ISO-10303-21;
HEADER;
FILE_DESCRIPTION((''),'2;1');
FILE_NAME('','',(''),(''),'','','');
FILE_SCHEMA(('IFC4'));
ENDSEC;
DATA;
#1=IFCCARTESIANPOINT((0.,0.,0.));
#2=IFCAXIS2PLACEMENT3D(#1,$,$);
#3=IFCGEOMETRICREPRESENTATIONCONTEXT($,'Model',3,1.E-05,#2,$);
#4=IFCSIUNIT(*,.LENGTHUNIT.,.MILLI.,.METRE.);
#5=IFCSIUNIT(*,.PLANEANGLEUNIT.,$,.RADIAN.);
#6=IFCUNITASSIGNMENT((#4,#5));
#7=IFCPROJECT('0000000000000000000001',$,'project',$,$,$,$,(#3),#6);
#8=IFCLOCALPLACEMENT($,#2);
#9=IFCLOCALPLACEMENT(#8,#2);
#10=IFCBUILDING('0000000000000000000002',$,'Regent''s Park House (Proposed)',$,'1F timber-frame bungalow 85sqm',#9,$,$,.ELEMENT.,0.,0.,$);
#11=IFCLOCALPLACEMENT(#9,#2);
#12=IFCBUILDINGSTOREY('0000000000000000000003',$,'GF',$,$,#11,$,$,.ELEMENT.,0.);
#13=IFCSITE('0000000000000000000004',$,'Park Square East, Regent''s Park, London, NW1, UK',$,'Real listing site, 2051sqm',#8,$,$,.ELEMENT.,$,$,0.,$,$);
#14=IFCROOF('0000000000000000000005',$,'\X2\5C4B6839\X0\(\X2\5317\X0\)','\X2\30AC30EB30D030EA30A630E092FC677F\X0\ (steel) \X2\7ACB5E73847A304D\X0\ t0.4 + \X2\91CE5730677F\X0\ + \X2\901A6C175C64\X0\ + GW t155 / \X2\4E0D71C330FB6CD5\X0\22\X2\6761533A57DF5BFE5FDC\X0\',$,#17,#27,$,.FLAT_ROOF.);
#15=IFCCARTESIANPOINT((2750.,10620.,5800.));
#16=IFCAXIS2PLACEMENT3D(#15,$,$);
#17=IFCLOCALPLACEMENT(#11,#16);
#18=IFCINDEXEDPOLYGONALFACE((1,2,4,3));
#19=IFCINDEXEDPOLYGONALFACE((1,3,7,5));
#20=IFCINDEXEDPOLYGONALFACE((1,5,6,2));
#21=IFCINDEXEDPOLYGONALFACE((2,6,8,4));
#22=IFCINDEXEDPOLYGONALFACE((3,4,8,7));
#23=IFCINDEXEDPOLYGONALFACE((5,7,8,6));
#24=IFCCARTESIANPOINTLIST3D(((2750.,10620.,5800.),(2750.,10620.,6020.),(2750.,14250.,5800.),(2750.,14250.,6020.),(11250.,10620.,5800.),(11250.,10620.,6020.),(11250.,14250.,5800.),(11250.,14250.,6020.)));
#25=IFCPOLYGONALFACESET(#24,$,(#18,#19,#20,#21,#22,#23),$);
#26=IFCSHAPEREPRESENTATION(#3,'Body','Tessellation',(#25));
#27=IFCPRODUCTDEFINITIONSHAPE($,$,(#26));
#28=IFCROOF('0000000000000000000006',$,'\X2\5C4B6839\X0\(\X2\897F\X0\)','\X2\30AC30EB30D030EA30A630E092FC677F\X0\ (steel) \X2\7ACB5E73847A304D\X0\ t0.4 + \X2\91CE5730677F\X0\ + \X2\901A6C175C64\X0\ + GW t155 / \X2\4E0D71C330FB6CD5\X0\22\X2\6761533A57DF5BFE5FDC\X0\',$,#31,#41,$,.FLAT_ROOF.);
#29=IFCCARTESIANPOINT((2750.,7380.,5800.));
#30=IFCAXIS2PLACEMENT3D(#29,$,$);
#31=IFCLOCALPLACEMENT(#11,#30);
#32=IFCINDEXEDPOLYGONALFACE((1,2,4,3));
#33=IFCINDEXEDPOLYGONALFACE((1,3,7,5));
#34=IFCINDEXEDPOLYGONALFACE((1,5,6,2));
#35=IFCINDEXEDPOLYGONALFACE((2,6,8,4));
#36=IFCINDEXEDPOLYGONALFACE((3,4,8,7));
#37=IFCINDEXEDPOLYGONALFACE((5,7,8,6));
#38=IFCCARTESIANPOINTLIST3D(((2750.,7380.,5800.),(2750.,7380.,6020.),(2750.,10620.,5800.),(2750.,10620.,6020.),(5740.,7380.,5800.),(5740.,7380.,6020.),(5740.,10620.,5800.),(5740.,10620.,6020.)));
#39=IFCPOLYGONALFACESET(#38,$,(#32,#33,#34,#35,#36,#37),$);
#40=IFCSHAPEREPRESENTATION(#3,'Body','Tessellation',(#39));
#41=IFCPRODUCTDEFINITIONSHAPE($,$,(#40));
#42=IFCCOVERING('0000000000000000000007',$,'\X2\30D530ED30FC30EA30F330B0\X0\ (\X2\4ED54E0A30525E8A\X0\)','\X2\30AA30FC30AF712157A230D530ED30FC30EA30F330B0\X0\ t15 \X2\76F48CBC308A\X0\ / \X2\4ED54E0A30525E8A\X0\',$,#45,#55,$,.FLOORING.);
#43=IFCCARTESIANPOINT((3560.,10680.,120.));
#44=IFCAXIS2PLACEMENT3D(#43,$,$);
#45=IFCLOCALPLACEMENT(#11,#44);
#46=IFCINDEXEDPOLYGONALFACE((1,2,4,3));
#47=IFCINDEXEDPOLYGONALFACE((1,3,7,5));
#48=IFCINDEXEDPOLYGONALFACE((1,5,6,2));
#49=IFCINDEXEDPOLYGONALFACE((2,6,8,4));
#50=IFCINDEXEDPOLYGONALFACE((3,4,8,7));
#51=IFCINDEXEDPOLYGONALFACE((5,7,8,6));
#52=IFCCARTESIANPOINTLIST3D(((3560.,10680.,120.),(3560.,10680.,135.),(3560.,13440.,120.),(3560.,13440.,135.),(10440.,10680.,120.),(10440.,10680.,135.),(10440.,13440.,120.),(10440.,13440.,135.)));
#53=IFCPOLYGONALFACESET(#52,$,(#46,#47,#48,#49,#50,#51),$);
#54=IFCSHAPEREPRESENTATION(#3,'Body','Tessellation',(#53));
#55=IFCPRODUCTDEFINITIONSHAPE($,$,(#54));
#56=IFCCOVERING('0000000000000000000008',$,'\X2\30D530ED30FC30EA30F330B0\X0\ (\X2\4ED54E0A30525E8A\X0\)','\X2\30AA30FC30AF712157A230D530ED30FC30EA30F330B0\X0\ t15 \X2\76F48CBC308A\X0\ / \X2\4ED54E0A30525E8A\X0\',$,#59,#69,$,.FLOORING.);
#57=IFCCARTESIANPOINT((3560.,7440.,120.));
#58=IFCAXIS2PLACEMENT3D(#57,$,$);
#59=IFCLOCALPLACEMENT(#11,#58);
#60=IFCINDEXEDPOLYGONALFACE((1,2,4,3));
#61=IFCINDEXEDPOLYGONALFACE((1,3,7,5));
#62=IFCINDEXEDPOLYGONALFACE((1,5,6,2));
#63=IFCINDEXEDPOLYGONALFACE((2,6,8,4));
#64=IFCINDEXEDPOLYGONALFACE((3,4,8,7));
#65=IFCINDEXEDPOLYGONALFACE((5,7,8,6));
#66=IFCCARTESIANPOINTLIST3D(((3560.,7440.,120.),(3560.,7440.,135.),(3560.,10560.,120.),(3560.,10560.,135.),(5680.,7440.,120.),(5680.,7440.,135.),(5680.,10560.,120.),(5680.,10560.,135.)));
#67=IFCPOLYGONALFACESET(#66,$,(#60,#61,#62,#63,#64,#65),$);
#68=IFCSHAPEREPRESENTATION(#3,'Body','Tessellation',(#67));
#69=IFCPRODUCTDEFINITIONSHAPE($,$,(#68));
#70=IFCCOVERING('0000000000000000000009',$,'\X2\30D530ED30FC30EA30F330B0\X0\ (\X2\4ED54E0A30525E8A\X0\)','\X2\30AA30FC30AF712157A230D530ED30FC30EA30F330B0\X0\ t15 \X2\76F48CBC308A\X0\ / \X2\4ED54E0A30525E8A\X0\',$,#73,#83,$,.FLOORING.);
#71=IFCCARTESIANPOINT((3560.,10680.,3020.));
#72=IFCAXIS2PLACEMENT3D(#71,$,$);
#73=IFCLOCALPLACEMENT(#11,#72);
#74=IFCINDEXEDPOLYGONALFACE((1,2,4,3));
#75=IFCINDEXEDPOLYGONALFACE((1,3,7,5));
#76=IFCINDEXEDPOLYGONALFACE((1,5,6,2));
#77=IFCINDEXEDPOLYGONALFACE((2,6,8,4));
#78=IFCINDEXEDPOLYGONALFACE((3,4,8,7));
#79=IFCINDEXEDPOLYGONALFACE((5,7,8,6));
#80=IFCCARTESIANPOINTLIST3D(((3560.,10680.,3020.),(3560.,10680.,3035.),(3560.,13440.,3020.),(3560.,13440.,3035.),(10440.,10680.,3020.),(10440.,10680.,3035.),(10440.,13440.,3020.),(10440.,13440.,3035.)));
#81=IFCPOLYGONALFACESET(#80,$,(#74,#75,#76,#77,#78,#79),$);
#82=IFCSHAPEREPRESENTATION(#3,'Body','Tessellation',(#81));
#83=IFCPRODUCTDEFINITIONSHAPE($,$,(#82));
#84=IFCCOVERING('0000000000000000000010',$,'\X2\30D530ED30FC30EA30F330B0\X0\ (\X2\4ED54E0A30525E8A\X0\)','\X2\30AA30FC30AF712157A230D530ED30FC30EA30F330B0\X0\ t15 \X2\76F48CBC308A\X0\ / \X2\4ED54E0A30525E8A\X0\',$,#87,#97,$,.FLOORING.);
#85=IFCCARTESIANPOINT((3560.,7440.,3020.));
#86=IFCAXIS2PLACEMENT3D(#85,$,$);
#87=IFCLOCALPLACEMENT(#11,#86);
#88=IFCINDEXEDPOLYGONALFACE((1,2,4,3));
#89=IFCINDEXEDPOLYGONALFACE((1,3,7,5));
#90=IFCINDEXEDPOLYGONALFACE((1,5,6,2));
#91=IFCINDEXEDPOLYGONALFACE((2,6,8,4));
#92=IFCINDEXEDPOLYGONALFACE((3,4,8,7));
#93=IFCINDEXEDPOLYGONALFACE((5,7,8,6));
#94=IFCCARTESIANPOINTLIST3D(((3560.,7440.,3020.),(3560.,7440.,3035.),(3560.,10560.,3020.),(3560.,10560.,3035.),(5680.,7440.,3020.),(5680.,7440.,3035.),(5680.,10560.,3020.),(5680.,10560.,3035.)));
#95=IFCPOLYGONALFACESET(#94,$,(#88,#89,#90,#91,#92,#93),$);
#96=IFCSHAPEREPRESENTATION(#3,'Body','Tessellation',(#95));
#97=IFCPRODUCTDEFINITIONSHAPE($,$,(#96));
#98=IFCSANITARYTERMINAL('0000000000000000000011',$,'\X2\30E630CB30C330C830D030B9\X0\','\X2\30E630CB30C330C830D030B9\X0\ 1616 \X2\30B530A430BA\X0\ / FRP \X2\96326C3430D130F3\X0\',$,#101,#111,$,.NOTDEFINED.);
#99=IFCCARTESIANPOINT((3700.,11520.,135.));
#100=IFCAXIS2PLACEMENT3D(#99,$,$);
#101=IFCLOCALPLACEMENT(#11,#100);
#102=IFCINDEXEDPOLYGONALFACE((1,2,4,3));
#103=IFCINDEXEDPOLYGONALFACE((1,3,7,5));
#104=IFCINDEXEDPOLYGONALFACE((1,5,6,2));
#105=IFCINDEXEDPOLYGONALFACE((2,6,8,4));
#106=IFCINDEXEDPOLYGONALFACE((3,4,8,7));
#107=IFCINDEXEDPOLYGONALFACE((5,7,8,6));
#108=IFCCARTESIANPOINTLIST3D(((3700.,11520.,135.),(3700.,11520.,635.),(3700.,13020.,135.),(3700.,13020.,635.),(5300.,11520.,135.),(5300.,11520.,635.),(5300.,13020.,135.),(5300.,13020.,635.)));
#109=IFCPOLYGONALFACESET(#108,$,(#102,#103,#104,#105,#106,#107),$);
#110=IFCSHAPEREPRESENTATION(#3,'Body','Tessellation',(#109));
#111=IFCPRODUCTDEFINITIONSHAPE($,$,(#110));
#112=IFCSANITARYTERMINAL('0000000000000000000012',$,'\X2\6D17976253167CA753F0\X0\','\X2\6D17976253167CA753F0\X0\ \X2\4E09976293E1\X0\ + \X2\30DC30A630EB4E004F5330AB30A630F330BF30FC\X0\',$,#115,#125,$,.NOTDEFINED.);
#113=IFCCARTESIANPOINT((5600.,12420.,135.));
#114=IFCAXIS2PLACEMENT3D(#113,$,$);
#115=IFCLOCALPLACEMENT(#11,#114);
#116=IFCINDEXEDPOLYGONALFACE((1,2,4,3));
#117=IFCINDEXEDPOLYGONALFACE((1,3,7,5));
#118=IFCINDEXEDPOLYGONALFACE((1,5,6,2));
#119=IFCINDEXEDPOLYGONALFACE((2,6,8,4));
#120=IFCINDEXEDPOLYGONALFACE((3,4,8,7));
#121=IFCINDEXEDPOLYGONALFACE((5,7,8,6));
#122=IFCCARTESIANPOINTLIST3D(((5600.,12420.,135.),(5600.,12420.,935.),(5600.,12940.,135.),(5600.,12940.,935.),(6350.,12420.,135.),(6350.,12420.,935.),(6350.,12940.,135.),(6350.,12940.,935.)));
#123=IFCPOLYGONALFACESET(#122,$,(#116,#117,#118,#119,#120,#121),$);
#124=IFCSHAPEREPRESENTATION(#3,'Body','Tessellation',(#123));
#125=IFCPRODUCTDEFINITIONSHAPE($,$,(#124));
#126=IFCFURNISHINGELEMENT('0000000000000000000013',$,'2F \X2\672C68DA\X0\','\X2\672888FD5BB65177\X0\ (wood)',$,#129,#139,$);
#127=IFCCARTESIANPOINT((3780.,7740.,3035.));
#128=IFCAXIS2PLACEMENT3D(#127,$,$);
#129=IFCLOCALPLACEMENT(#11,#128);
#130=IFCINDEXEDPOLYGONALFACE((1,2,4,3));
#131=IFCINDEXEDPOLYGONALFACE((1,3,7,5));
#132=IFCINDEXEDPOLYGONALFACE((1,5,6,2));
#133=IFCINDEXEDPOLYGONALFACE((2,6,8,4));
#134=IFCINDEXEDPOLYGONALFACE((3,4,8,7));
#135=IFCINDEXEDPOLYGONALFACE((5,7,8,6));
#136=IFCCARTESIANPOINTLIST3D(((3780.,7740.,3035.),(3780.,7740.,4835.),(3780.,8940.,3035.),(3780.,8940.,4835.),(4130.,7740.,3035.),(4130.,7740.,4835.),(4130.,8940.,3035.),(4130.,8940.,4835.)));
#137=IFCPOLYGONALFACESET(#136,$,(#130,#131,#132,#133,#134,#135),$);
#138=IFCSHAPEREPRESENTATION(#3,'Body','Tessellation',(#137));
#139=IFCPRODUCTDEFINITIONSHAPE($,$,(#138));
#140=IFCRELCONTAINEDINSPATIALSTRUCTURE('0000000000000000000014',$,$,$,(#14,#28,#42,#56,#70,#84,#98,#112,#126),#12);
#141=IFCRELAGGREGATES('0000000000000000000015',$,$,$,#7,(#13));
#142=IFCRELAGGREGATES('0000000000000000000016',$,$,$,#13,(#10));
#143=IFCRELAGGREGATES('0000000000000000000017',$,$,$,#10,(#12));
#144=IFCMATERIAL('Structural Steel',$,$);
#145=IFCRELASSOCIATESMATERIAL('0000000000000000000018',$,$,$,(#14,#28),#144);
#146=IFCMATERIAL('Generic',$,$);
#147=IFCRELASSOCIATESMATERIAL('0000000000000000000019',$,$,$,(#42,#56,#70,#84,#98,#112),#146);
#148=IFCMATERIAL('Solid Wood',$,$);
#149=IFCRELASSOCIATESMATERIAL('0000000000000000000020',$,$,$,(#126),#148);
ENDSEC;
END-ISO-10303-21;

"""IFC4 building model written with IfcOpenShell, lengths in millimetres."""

from ifc_helpers import new_model, si_unit, frame, frame_2d, origin, place, context, project, spatial, rectangle, extrude, material, element, save


model = new_model("IFC4")

# Units and contexts
model_context = context("Model", 3, precision=1e-05, world=origin())
ifc_project = project(units=[si_unit("LENGTHUNIT", "METRE", prefix="MILLI"), si_unit("PLANEANGLEUNIT", "RADIAN")], contexts=[model_context])

# Site, building, storey
site_placement = place(None, origin())
site = spatial("IfcSite", under=ifc_project, at=site_placement, Name="Park Square East, Regent's Park, London, NW1, UK", ObjectType="Real listing site, 2051sqm", CompositionType="ELEMENT", RefElevation=0.0)
building_placement = place(site_placement, origin())
building = spatial("IfcBuilding", under=site, at=building_placement, Name="Regent's Park House (Proposed)", ObjectType="1F timber-frame bungalow 85sqm", CompositionType="ELEMENT", ElevationOfRefHeight=0.0, ElevationOfTerrain=0.0)
storey_placement = place(building_placement, origin())
storey = spatial("IfcBuildingStorey", under=building, at=storey_placement, Name="GF", CompositionType="ELEMENT", Elevation=0.0)

# Shared definitions
ifc_material_1 = material(Name="Solid Wood")

# Roofs
ifc_material_2 = material(Name="Structural Steel")
for number, where, name in (
    (1, (2750.0, 10620.0, 5800.0), "屋根(北)"),
):
    element("IfcRoof", number, at=place(storey_placement, frame(where)), inside=storey, material=ifc_material_2, Name=name, Description="ガルバリウム鋼板 (steel) 立平葺き t0.4 + 野地板 + 通気層 + GW t155 / 不燃・法22条区域対応", PredefinedType="FLAT_ROOF", context=model_context, shape_type="SweptSolid", body=[
        extrude(rectangle(XDim=8500.0, YDim=3630.0, at=frame_2d((4250.0, 1815.0))), frame((2750.0, 10620.0, 5800.0)), (0.0, 0.0, 1.0), 220.0),
    ])
roof_placement = place(storey_placement, frame((2750.0, 7380.0, 5800.0)))
element("IfcRoof", 2, at=roof_placement, inside=storey, material=ifc_material_2, Name="屋根(西)", Description="ガルバリウム鋼板 (steel) 立平葺き t0.4 + 野地板 + 通気層 + GW t155 / 不燃・法22条区域対応", PredefinedType="FLAT_ROOF", context=model_context, shape_type="SweptSolid", body=[
    extrude(rectangle(XDim=2990.0, YDim=3240.0, at=frame_2d((1495.0, 1620.0))), frame((2750.0, 7380.0, 5800.0)), (0.0, 0.0, 1.0), 220.0),
])

# Coverings
ifc_material_3 = material(Name="Generic")
covering_1_placement = place(storey_placement, frame((3560.0, 10680.0, 120.0)))
element("IfcCovering", 3, at=covering_1_placement, inside=storey, material=ifc_material_3, Name="フローリング (仕上げ床)", Description="オーク無垢フローリング t15 直貼り / 仕上げ床", PredefinedType="FLOORING", context=model_context, shape_type="SweptSolid", body=[
    extrude(rectangle(XDim=6880.0, YDim=2760.0, at=frame_2d((3440.0, 1380.0))), frame((3560.0, 10680.0, 120.0)), (0.0, 0.0, 1.0), 15.0),
])
covering_2_placement = place(storey_placement, frame((3560.0, 7440.0, 120.0)))
element("IfcCovering", 4, at=covering_2_placement, inside=storey, material=ifc_material_3, Name="フローリング (仕上げ床)", Description="オーク無垢フローリング t15 直貼り / 仕上げ床", PredefinedType="FLOORING", context=model_context, shape_type="SweptSolid", body=[
    extrude(rectangle(XDim=2120.0, YDim=3120.0, at=frame_2d((1060.0, 1560.0))), frame((3560.0, 7440.0, 120.0)), (0.0, 0.0, 1.0), 15.0),
])
covering_3_placement = place(storey_placement, frame((3560.0, 10680.0, 3020.0)))
element("IfcCovering", 5, at=covering_3_placement, inside=storey, material=ifc_material_3, Name="フローリング (仕上げ床)", Description="オーク無垢フローリング t15 直貼り / 仕上げ床", PredefinedType="FLOORING", context=model_context, shape_type="SweptSolid", body=[
    extrude(rectangle(XDim=6880.0, YDim=2760.0, at=frame_2d((3440.0, 1380.0))), frame((3560.0, 10680.0, 3020.0)), (0.0, 0.0, 1.0), 15.0),
])
covering_4_placement = place(storey_placement, frame((3560.0, 7440.0, 3020.0)))
element("IfcCovering", 6, at=covering_4_placement, inside=storey, material=ifc_material_3, Name="フローリング (仕上げ床)", Description="オーク無垢フローリング t15 直貼り / 仕上げ床", PredefinedType="FLOORING", context=model_context, shape_type="SweptSolid", body=[
    extrude(rectangle(XDim=2120.0, YDim=3120.0, at=frame_2d((1060.0, 1560.0))), frame((3560.0, 7440.0, 3020.0)), (0.0, 0.0, 1.0), 15.0),
])

# Sanitary terminals
sanitary_terminal_1_placement = place(storey_placement, frame((3700.0, 11520.0, 135.0)))
element("IfcSanitaryTerminal", 7, at=sanitary_terminal_1_placement, inside=storey, material=ifc_material_3, Name="ユニットバス", Description="ユニットバス 1616 サイズ / FRP 防水パン", PredefinedType="NOTDEFINED", context=model_context, shape_type="SweptSolid", body=[
    extrude(rectangle(XDim=1600.0, YDim=1500.0, at=frame_2d((800.0, 750.0))), frame((3700.0, 11520.0, 135.0)), (0.0, 0.0, 1.0), 500.0),
])
sanitary_terminal_2_placement = place(storey_placement, frame((5600.0, 12420.0, 135.0)))
element("IfcSanitaryTerminal", 8, at=sanitary_terminal_2_placement, inside=storey, material=ifc_material_3, Name="洗面化粧台", Description="洗面化粧台 三面鏡 + ボウル一体カウンター", PredefinedType="NOTDEFINED", context=model_context, shape_type="SweptSolid", body=[
    extrude(rectangle(XDim=750.0, YDim=520.0, at=frame_2d((375.0, 260.0))), frame((5600.0, 12420.0, 135.0)), (0.0, 0.0, 1.0), 800.0),
])

# Furnishing element
furnishing_placement = place(storey_placement, frame((3780.0, 7740.0, 3035.0)))
element("IfcFurnishingElement", 9, at=furnishing_placement, inside=storey, material=ifc_material_1, Name="2F 本棚", Description="木製家具 (wood)", context=model_context, shape_type="SweptSolid", body=[
    extrude(rectangle(XDim=350.0, YDim=1200.0, at=frame_2d((175.0, 600.0))), frame((3780.0, 7740.0, 3035.0)), (0.0, 0.0, 1.0), 1800.0),
])

save(model, "model.ifc")
